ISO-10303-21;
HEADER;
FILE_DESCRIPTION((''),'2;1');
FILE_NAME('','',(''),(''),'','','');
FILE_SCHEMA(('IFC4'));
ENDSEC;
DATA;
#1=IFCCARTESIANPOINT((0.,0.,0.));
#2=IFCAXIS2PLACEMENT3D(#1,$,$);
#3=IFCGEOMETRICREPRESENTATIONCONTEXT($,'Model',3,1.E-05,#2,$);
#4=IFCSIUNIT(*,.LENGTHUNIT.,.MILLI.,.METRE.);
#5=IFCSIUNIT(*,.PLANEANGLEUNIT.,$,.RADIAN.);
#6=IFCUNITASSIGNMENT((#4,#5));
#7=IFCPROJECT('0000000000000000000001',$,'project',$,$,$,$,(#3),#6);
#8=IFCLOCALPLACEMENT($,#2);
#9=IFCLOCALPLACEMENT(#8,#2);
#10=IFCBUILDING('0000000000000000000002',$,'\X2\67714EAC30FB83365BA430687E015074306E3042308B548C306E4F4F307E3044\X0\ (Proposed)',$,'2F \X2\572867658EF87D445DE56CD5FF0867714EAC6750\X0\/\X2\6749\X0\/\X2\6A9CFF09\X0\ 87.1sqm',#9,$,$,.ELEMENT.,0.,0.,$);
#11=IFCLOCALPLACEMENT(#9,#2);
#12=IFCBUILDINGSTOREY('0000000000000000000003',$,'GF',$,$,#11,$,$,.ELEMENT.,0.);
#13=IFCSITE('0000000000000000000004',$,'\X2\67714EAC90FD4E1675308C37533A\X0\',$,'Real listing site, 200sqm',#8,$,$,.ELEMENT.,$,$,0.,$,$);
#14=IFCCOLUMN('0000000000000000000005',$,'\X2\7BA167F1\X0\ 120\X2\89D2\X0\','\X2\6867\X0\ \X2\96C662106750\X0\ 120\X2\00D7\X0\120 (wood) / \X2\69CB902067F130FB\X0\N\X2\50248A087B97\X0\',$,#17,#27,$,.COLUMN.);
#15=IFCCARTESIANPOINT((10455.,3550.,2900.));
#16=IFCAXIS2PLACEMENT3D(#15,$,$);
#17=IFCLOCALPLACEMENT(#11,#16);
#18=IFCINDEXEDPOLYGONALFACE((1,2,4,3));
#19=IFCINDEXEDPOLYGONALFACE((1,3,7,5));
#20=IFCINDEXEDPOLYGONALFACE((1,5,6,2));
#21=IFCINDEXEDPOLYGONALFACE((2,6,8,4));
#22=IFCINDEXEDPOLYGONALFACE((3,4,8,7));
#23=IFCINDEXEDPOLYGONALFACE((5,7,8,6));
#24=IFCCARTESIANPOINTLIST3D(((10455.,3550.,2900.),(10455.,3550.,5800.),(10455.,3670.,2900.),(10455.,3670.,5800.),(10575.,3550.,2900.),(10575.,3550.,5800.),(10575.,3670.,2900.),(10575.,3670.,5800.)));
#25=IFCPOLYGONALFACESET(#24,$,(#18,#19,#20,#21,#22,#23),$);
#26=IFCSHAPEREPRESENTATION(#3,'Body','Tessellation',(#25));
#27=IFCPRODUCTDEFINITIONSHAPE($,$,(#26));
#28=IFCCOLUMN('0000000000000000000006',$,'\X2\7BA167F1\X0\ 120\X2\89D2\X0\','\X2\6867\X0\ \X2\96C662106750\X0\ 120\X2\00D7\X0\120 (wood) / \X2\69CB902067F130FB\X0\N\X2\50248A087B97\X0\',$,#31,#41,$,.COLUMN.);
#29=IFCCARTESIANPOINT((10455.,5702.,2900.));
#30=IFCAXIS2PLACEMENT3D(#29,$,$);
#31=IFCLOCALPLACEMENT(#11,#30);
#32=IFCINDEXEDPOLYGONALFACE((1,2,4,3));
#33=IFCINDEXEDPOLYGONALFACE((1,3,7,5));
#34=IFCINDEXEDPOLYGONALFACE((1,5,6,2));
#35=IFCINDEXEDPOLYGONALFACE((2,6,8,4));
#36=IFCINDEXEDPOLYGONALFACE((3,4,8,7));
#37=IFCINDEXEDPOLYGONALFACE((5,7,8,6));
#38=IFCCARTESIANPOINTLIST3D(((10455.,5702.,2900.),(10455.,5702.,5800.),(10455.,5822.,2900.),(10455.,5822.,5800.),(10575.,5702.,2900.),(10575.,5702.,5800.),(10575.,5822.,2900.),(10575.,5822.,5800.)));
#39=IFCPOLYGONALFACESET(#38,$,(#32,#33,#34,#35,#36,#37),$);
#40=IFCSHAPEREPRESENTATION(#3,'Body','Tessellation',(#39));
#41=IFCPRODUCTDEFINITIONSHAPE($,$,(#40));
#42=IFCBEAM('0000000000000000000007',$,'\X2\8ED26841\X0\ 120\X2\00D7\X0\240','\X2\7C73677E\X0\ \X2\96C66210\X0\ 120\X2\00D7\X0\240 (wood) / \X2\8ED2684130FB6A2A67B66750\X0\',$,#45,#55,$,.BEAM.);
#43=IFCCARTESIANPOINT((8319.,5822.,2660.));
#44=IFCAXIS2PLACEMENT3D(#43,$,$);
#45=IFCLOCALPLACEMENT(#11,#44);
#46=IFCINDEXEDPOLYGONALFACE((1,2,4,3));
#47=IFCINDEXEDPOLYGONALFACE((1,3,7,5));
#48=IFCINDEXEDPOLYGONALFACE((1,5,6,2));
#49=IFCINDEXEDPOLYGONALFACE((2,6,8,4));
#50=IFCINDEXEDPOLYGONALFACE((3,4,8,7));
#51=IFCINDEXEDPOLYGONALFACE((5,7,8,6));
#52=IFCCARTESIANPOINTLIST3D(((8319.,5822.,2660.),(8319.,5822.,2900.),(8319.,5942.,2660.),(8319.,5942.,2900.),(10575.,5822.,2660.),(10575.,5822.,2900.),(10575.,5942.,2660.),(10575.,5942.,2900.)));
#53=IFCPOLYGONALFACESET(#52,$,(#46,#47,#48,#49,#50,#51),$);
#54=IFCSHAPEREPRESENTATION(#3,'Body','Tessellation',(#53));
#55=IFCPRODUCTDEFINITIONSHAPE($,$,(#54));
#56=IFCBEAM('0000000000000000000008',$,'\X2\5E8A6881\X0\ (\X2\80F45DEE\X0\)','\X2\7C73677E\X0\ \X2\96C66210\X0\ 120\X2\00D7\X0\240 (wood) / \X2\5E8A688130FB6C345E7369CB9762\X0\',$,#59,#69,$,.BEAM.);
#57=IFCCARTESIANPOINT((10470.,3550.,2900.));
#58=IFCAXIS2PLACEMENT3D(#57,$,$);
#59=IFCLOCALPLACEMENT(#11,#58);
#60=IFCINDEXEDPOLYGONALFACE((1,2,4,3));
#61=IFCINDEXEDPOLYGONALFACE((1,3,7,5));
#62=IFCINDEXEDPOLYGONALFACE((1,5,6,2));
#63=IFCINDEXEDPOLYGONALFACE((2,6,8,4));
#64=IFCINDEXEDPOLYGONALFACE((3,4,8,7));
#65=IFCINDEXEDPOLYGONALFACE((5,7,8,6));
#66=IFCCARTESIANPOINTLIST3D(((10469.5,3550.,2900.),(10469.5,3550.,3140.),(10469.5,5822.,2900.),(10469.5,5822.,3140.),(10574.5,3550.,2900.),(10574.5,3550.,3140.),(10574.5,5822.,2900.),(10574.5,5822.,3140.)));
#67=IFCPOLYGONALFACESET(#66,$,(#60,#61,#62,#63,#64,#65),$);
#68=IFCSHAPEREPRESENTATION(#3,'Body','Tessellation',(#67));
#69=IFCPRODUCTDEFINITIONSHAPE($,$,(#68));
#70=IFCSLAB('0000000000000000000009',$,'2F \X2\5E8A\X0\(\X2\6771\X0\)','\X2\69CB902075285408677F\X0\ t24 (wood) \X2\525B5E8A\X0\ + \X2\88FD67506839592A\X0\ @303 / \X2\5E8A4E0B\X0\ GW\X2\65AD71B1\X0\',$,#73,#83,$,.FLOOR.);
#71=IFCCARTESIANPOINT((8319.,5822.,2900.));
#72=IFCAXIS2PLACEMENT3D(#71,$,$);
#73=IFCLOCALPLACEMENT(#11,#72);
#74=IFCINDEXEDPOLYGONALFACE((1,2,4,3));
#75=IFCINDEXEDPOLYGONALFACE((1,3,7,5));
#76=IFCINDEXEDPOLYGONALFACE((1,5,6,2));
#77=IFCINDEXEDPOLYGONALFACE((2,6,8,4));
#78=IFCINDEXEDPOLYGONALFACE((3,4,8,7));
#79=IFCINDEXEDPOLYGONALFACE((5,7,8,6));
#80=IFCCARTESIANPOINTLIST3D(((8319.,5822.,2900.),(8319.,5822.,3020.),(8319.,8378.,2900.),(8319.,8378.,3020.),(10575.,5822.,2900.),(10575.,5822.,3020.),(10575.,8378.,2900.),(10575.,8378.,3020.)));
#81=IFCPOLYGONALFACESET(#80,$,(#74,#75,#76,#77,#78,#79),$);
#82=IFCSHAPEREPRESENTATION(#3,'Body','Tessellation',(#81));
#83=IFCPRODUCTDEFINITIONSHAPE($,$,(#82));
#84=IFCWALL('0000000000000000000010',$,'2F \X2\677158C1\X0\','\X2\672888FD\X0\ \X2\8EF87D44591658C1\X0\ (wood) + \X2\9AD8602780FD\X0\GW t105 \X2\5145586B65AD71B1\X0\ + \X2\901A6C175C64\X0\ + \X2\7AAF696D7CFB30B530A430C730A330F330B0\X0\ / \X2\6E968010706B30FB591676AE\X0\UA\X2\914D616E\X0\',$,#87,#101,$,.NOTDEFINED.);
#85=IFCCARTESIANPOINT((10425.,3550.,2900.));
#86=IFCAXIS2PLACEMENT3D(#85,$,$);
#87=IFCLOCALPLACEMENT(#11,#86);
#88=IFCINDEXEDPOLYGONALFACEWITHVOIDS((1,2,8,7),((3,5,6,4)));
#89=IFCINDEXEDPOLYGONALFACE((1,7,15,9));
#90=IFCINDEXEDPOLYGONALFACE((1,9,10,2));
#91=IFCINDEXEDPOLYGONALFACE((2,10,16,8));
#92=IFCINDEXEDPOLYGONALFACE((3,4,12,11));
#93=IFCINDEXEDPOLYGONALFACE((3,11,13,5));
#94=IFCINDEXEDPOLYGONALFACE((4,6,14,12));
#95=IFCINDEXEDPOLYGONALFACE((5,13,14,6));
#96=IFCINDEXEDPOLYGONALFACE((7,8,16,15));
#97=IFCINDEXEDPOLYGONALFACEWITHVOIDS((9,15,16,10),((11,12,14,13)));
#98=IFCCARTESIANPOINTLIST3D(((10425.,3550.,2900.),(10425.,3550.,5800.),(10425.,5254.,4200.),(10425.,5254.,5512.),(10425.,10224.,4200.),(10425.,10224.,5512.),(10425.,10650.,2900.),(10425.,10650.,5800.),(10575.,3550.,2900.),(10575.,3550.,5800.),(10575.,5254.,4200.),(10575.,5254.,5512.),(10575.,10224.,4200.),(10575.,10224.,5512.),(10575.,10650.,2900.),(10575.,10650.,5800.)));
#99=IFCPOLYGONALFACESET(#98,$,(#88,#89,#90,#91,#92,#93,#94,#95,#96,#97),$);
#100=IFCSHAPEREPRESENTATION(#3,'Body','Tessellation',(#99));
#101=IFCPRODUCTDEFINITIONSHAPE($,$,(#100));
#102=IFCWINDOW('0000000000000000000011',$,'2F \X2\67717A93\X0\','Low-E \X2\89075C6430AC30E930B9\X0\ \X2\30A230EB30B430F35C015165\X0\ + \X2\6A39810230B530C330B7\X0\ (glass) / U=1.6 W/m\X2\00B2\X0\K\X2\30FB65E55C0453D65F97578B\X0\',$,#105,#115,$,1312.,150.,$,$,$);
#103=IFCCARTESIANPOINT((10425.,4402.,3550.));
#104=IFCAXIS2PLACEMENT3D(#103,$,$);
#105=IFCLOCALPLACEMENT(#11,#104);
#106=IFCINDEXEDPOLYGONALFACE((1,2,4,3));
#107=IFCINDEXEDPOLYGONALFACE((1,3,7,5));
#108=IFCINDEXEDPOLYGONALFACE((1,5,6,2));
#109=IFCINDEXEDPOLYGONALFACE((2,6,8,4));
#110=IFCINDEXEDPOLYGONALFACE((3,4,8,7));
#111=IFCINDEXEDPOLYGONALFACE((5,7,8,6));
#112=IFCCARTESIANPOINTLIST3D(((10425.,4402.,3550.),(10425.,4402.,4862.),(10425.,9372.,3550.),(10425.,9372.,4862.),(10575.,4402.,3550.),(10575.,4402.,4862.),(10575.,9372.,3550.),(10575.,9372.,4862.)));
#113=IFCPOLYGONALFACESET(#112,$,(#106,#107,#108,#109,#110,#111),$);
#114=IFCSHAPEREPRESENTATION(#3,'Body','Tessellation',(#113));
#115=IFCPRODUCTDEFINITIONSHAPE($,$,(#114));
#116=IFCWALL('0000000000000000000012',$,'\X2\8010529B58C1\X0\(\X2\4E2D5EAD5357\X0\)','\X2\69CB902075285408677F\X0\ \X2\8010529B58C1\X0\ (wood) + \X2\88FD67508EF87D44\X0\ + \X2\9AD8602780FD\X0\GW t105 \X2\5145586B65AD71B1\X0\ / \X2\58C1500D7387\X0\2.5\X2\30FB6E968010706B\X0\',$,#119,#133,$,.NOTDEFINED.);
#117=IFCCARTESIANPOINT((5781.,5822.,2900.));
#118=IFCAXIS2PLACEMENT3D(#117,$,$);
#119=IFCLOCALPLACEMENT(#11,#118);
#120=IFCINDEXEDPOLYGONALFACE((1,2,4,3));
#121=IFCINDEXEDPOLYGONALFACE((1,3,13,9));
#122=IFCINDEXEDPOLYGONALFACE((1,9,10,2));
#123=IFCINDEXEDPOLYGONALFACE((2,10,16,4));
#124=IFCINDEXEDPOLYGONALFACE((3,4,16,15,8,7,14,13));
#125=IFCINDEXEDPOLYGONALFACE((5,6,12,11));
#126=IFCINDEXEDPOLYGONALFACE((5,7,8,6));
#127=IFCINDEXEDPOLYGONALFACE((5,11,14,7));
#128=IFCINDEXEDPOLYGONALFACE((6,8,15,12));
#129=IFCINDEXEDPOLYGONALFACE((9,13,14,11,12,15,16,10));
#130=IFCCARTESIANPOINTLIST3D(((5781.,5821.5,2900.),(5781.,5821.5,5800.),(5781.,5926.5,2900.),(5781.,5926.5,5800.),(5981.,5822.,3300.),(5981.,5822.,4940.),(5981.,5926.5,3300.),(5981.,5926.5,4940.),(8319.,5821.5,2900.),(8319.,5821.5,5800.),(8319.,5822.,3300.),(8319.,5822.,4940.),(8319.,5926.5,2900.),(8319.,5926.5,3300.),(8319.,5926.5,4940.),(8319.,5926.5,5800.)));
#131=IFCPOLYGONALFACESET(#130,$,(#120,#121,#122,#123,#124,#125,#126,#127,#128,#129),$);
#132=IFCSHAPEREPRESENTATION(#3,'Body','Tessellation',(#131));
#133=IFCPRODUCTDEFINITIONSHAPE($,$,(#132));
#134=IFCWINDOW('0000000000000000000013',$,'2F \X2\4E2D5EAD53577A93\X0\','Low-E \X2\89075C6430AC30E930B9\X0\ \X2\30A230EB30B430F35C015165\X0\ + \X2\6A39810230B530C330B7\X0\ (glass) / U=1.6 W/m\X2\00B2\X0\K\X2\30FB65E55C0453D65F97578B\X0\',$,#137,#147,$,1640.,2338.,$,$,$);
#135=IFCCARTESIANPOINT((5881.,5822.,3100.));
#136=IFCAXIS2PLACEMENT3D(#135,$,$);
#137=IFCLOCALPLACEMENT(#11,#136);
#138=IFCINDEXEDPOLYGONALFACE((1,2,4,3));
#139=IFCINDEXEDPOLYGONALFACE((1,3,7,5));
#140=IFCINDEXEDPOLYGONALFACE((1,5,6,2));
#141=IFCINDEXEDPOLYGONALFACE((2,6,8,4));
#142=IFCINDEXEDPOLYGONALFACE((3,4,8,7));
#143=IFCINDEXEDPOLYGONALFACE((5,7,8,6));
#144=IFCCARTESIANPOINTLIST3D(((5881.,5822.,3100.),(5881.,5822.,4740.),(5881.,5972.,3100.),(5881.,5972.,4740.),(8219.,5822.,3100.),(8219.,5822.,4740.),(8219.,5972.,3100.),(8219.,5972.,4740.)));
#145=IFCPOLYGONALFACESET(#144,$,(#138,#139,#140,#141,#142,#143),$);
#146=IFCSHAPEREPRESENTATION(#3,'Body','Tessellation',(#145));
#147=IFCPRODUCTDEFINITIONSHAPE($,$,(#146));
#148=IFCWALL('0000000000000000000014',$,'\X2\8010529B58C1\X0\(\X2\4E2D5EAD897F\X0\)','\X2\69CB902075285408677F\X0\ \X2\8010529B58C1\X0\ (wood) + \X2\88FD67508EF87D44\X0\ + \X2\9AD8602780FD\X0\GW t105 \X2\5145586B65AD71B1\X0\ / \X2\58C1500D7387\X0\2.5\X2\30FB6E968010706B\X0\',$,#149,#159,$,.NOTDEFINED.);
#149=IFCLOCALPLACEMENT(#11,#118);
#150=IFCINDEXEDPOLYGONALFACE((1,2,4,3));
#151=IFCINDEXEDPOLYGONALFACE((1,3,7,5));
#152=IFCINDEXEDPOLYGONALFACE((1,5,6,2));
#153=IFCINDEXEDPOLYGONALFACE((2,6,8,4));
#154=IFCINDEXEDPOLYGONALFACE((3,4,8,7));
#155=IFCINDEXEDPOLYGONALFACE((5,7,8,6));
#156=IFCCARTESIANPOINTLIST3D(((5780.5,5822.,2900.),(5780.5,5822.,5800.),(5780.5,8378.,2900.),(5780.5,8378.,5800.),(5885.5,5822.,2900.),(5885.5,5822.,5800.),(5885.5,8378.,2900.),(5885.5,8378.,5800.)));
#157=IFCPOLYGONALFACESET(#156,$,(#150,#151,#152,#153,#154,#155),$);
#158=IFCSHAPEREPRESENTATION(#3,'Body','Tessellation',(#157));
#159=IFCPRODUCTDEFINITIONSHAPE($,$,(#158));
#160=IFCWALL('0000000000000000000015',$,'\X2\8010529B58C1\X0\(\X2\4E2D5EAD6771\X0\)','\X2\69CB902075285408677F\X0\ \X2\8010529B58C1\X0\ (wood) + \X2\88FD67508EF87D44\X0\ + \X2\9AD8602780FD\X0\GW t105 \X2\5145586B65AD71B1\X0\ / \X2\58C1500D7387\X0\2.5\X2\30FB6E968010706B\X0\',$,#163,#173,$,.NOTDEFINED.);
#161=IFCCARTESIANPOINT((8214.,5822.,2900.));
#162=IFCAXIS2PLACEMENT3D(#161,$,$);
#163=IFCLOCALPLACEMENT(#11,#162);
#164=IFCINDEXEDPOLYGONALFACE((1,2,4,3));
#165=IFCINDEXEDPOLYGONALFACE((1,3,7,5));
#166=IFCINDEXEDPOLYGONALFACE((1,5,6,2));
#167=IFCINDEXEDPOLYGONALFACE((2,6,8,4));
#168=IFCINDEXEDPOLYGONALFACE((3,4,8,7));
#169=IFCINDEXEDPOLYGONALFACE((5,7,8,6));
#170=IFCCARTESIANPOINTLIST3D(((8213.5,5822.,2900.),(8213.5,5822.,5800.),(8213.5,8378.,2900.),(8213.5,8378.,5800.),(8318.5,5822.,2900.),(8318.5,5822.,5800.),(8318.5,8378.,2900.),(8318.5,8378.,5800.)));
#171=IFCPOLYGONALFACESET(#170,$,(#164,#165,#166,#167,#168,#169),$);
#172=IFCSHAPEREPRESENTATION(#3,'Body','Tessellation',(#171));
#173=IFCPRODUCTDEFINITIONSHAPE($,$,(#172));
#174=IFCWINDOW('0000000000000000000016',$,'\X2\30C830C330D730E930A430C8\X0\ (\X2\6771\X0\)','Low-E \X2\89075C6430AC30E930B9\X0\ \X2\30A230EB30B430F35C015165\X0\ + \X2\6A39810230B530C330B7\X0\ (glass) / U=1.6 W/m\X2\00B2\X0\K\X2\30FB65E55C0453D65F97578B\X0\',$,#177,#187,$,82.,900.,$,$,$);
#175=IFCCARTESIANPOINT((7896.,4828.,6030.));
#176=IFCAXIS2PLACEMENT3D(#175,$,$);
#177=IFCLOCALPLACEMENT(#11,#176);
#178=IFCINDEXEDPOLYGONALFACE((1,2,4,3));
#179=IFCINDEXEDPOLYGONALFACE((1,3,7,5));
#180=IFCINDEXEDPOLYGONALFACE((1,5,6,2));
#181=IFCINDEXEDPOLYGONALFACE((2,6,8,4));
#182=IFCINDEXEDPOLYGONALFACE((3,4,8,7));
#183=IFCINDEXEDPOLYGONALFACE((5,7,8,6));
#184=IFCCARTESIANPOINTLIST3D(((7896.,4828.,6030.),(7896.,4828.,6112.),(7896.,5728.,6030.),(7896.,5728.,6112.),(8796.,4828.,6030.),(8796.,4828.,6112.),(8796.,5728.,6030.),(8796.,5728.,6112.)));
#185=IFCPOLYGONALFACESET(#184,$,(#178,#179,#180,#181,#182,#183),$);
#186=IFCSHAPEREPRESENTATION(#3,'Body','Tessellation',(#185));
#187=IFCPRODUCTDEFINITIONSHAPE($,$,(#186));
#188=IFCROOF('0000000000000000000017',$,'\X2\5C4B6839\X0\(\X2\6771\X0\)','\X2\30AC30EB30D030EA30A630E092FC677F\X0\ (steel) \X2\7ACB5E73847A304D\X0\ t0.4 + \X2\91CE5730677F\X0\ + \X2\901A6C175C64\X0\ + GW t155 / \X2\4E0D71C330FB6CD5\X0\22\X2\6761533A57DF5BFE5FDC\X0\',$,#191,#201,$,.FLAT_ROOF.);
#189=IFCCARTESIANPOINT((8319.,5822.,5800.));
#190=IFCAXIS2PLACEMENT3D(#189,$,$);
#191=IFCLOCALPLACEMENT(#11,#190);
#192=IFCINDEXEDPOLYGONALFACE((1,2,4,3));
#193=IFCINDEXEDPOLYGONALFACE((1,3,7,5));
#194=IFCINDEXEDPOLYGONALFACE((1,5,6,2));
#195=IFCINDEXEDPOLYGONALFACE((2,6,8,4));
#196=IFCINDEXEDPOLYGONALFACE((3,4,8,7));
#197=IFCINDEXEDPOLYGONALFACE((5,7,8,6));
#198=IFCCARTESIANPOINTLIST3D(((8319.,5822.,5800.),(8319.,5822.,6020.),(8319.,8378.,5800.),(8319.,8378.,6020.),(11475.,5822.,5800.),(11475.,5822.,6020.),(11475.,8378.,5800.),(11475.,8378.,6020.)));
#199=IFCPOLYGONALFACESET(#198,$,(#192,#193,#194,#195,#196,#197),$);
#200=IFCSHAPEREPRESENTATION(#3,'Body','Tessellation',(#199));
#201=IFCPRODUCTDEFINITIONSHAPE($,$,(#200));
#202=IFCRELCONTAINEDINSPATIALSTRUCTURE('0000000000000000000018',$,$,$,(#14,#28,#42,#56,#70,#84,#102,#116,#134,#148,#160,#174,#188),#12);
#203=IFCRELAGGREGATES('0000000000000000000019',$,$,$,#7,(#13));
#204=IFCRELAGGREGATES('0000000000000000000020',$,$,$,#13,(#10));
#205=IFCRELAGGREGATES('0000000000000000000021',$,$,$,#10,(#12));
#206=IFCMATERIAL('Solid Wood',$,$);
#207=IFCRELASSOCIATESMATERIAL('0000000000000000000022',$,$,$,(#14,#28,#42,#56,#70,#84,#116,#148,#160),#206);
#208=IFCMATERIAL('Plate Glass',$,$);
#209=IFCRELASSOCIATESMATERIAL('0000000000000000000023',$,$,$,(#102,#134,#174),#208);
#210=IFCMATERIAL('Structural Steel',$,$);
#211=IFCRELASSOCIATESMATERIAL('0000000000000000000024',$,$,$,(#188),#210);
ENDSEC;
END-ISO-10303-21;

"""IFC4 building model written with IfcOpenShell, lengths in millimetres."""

from ifc_helpers import new_model, si_unit, frame, frame_2d, origin, place, context, project, spatial, rectangle, extrude, material, element, fill, save


model = new_model("IFC4")

# Units and contexts
model_context = context("Model", 3, precision=1e-05, world=origin())
ifc_project = project(units=[si_unit("LENGTHUNIT", "METRE", prefix="MILLI"), si_unit("PLANEANGLEUNIT", "RADIAN")], contexts=[model_context])

# Site, building, storey
site_placement = place(None, origin())
site = spatial("IfcSite", under=ifc_project, at=site_placement, Name="東京都世田谷区", ObjectType="Real listing site, 200sqm", CompositionType="ELEMENT", RefElevation=0.0)
building_placement = place(site_placement, origin())
building = spatial("IfcBuilding", under=site, at=building_placement, Name="東京・茶室と縁側のある和の住まい (Proposed)", ObjectType="2F 在来軸組工法（東京材/杉/檜） 87.1sqm", CompositionType="ELEMENT", ElevationOfRefHeight=0.0, ElevationOfTerrain=0.0)
storey_placement = place(building_placement, origin())
storey = spatial("IfcBuildingStorey", under=building, at=storey_placement, Name="GF", CompositionType="ELEMENT", Elevation=0.0)

# Columns
ifc_material_1 = material(Name="Solid Wood")
column_1_placement = place(storey_placement, frame((10455.0, 3550.0, 2900.0)))
element("IfcColumn", 1, at=column_1_placement, inside=storey, material=ifc_material_1, Name="管柱 120角", Description="桧 集成材 120×120 (wood) / 構造柱・N値計算", PredefinedType="COLUMN", context=model_context, shape_type="SweptSolid", body=[
    extrude(rectangle(XDim=120.0, YDim=120.0, at=frame_2d((60.0, 60.0))), frame((10455.0, 3550.0, 2900.0)), (0.0, 0.0, 1.0), 2900.0),
])
column_2_placement = place(storey_placement, frame((10455.0, 5702.0, 2900.0)))
element("IfcColumn", 2, at=column_2_placement, inside=storey, material=ifc_material_1, Name="管柱 120角", Description="桧 集成材 120×120 (wood) / 構造柱・N値計算", PredefinedType="COLUMN", context=model_context, shape_type="SweptSolid", body=[
    extrude(rectangle(XDim=120.0, YDim=120.0, at=frame_2d((60.0, 60.0))), frame((10455.0, 5702.0, 2900.0)), (0.0, 0.0, 1.0), 2900.0),
])

# Beams
beam_1_placement = place(storey_placement, frame((8319.0, 5822.0, 2660.0)))
element("IfcBeam", 3, at=beam_1_placement, inside=storey, material=ifc_material_1, Name="軒桁 120×240", Description="米松 集成 120×240 (wood) / 軒桁・横架材", PredefinedType="BEAM", context=model_context, shape_type="SweptSolid", body=[
    extrude(rectangle(XDim=2256.0, YDim=120.0, at=frame_2d((1128.0, 60.0))), frame((8319.0, 5822.0, 2660.0)), (0.0, 0.0, 1.0), 240.0),
])
beam_2_placement = place(storey_placement, frame((10470.0, 3550.0, 2900.0)))
element("IfcBeam", 4, at=beam_2_placement, inside=storey, material=ifc_material_1, Name="床梁 (胴差)", Description="米松 集成 120×240 (wood) / 床梁・水平構面", PredefinedType="BEAM", context=model_context, shape_type="SweptSolid", body=[
    extrude(rectangle(XDim=105.0, YDim=2272.0, at=frame_2d((52.0, 1136.0))), frame((10470.0, 3550.0, 2900.0)), (0.0, 0.0, 1.0), 240.0),
])

# Slab
slab_placement = place(storey_placement, frame((8319.0, 5822.0, 2900.0)))
element("IfcSlab", 5, at=slab_placement, inside=storey, material=ifc_material_1, Name="2F 床(東)", Description="構造用合板 t24 (wood) 剛床 + 製材根太 @303 / 床下 GW断熱", PredefinedType="FLOOR", context=model_context, shape_type="SweptSolid", body=[
    extrude(rectangle(XDim=2256.0, YDim=2556.0, at=frame_2d((1128.0, 1278.0))), frame((8319.0, 5822.0, 2900.0)), (0.0, 0.0, 1.0), 120.0),
])

# Walls, openings, windows
wall_1_placement = place(storey_placement, frame((10425.0, 3550.0, 2900.0)))
wall_1 = element("IfcWall", 6, at=wall_1_placement, inside=storey, material=ifc_material_1, Name="2F 東壁", Description="木製 軸組外壁 (wood) + 高性能GW t105 充填断熱 + 通気層 + 窯業系サイディング / 準耐火・外皮UA配慮", PredefinedType="NOTDEFINED", context=model_context, shape_type="SweptSolid", body=[
    extrude(rectangle(XDim=150.0, YDim=7100.0, at=frame_2d((75.0, 3550.0))), frame((10425.0, 3550.0, 2900.0)), (0.0, 0.0, 1.0), 2900.0),
])
opening_1_placement = place(storey_placement, frame((10425.0, 4402.0, 3550.0)))
opening_1 = element("IfcOpeningElement", 7, at=opening_1_placement, cuts=wall_1, PredefinedType="NOTDEFINED", context=model_context, shape_type="SweptSolid", body=[
    extrude(rectangle(XDim=150.0, YDim=4970.0, at=frame_2d((75.0, 2485.0))), frame((10425.0, 4402.0, 3550.0)), (0.0, 0.0, 1.0), 1312.0),
])
ifc_material_2 = material(Name="Plate Glass")
window_1_placement = place(storey_placement, frame((10425.0, 4402.0, 3550.0)))
window_1 = element("IfcWindow", 8, at=window_1_placement, inside=storey, material=ifc_material_2, Name="2F 東窓", Description="Low-E 複層ガラス アルゴン封入 + 樹脂サッシ (glass) / U=1.6 W/m²K・日射取得型", OverallHeight=1312.0, OverallWidth=150.0, context=model_context, shape_type="SweptSolid", body=[
    extrude(rectangle(XDim=150.0, YDim=4970.0, at=frame_2d((75.0, 2485.0))), frame((10425.0, 4402.0, 3550.0)), (0.0, 0.0, 1.0), 1312.0),
])
fill(opening_1, window_1)
wall_2_placement = place(storey_placement, frame((5781.0, 5822.0, 2900.0)))
wall_2 = element("IfcWall", 9, at=wall_2_placement, inside=storey, material=ifc_material_1, Name="耐力壁(中庭南)", Description="構造用合板 耐力壁 (wood) + 製材軸組 + 高性能GW t105 充填断熱 / 壁倍率2.5・準耐火", PredefinedType="NOTDEFINED", context=model_context, shape_type="SweptSolid", body=[
    extrude(rectangle(XDim=2538.0, YDim=105.0, at=frame_2d((1269.0, 52.0))), frame((5781.0, 5822.0, 2900.0)), (0.0, 0.0, 1.0), 2900.0),
])
opening_2_placement = place(storey_placement, frame((5881.0, 5822.0, 3100.0)))
opening_2 = element("IfcOpeningElement", 10, at=opening_2_placement, cuts=wall_2, PredefinedType="NOTDEFINED", context=model_context, shape_type="SweptSolid", body=[
    extrude(rectangle(XDim=2338.0, YDim=150.0, at=frame_2d((1169.0, 75.0))), frame((5881.0, 5822.0, 3100.0)), (0.0, 0.0, 1.0), 1640.0),
])
window_2_placement = place(storey_placement, frame((5881.0, 5822.0, 3100.0)))
window_2 = element("IfcWindow", 11, at=window_2_placement, inside=storey, material=ifc_material_2, Name="2F 中庭南窓", Description="Low-E 複層ガラス アルゴン封入 + 樹脂サッシ (glass) / U=1.6 W/m²K・日射取得型", OverallHeight=1640.0, OverallWidth=2338.0, context=model_context, shape_type="SweptSolid", body=[
    extrude(rectangle(XDim=2338.0, YDim=150.0, at=frame_2d((1169.0, 75.0))), frame((5881.0, 5822.0, 3100.0)), (0.0, 0.0, 1.0), 1640.0),
])
fill(opening_2, window_2)

# Walls
wall_3_placement = place(storey_placement, frame((5781.0, 5822.0, 2900.0)))
element("IfcWall", 12, at=wall_3_placement, inside=storey, material=ifc_material_1, Name="耐力壁(中庭西)", Description="構造用合板 耐力壁 (wood) + 製材軸組 + 高性能GW t105 充填断熱 / 壁倍率2.5・準耐火", PredefinedType="NOTDEFINED", context=model_context, shape_type="SweptSolid", body=[
    extrude(rectangle(XDim=105.0, YDim=2556.0, at=frame_2d((52.0, 1278.0))), frame((5781.0, 5822.0, 2900.0)), (0.0, 0.0, 1.0), 2900.0),
])
wall_4_placement = place(storey_placement, frame((8214.0, 5822.0, 2900.0)))
element("IfcWall", 13, at=wall_4_placement, inside=storey, material=ifc_material_1, Name="耐力壁(中庭東)", Description="構造用合板 耐力壁 (wood) + 製材軸組 + 高性能GW t105 充填断熱 / 壁倍率2.5・準耐火", PredefinedType="NOTDEFINED", context=model_context, shape_type="SweptSolid", body=[
    extrude(rectangle(XDim=105.0, YDim=2556.0, at=frame_2d((52.0, 1278.0))), frame((8214.0, 5822.0, 2900.0)), (0.0, 0.0, 1.0), 2900.0),
])

# Window
window_3_placement = place(storey_placement, frame((7896.0, 4828.0, 6030.0)))
element("IfcWindow", 14, at=window_3_placement, inside=storey, material=ifc_material_2, Name="トップライト (東)", Description="Low-E 複層ガラス アルゴン封入 + 樹脂サッシ (glass) / U=1.6 W/m²K・日射取得型", OverallHeight=82.0, OverallWidth=900.0, context=model_context, shape_type="SweptSolid", body=[
    extrude(rectangle(XDim=900.0, YDim=900.0, at=frame_2d((450.0, 450.0))), frame((7896.0, 4828.0, 6030.0)), (0.0, 0.0, 1.0), 82.0),
])

# Roof
ifc_material_3 = material(Name="Structural Steel")
for number, where, name in (
    (15, (8319.0, 5822.0, 5800.0), "屋根(東)"),
):
    element("IfcRoof", number, at=place(storey_placement, frame(where)), inside=storey, material=ifc_material_3, Name=name, Description="ガルバリウム鋼板 (steel) 立平葺き t0.4 + 野地板 + 通気層 + GW t155 / 不燃・法22条区域対応", PredefinedType="FLAT_ROOF", context=model_context, shape_type="SweptSolid", body=[
        extrude(rectangle(XDim=3156.0, YDim=2556.0, at=frame_2d((1578.0, 1278.0))), frame((8319.0, 5822.0, 5800.0)), (0.0, 0.0, 1.0), 220.0),
    ])

save(model, "model.ifc")
